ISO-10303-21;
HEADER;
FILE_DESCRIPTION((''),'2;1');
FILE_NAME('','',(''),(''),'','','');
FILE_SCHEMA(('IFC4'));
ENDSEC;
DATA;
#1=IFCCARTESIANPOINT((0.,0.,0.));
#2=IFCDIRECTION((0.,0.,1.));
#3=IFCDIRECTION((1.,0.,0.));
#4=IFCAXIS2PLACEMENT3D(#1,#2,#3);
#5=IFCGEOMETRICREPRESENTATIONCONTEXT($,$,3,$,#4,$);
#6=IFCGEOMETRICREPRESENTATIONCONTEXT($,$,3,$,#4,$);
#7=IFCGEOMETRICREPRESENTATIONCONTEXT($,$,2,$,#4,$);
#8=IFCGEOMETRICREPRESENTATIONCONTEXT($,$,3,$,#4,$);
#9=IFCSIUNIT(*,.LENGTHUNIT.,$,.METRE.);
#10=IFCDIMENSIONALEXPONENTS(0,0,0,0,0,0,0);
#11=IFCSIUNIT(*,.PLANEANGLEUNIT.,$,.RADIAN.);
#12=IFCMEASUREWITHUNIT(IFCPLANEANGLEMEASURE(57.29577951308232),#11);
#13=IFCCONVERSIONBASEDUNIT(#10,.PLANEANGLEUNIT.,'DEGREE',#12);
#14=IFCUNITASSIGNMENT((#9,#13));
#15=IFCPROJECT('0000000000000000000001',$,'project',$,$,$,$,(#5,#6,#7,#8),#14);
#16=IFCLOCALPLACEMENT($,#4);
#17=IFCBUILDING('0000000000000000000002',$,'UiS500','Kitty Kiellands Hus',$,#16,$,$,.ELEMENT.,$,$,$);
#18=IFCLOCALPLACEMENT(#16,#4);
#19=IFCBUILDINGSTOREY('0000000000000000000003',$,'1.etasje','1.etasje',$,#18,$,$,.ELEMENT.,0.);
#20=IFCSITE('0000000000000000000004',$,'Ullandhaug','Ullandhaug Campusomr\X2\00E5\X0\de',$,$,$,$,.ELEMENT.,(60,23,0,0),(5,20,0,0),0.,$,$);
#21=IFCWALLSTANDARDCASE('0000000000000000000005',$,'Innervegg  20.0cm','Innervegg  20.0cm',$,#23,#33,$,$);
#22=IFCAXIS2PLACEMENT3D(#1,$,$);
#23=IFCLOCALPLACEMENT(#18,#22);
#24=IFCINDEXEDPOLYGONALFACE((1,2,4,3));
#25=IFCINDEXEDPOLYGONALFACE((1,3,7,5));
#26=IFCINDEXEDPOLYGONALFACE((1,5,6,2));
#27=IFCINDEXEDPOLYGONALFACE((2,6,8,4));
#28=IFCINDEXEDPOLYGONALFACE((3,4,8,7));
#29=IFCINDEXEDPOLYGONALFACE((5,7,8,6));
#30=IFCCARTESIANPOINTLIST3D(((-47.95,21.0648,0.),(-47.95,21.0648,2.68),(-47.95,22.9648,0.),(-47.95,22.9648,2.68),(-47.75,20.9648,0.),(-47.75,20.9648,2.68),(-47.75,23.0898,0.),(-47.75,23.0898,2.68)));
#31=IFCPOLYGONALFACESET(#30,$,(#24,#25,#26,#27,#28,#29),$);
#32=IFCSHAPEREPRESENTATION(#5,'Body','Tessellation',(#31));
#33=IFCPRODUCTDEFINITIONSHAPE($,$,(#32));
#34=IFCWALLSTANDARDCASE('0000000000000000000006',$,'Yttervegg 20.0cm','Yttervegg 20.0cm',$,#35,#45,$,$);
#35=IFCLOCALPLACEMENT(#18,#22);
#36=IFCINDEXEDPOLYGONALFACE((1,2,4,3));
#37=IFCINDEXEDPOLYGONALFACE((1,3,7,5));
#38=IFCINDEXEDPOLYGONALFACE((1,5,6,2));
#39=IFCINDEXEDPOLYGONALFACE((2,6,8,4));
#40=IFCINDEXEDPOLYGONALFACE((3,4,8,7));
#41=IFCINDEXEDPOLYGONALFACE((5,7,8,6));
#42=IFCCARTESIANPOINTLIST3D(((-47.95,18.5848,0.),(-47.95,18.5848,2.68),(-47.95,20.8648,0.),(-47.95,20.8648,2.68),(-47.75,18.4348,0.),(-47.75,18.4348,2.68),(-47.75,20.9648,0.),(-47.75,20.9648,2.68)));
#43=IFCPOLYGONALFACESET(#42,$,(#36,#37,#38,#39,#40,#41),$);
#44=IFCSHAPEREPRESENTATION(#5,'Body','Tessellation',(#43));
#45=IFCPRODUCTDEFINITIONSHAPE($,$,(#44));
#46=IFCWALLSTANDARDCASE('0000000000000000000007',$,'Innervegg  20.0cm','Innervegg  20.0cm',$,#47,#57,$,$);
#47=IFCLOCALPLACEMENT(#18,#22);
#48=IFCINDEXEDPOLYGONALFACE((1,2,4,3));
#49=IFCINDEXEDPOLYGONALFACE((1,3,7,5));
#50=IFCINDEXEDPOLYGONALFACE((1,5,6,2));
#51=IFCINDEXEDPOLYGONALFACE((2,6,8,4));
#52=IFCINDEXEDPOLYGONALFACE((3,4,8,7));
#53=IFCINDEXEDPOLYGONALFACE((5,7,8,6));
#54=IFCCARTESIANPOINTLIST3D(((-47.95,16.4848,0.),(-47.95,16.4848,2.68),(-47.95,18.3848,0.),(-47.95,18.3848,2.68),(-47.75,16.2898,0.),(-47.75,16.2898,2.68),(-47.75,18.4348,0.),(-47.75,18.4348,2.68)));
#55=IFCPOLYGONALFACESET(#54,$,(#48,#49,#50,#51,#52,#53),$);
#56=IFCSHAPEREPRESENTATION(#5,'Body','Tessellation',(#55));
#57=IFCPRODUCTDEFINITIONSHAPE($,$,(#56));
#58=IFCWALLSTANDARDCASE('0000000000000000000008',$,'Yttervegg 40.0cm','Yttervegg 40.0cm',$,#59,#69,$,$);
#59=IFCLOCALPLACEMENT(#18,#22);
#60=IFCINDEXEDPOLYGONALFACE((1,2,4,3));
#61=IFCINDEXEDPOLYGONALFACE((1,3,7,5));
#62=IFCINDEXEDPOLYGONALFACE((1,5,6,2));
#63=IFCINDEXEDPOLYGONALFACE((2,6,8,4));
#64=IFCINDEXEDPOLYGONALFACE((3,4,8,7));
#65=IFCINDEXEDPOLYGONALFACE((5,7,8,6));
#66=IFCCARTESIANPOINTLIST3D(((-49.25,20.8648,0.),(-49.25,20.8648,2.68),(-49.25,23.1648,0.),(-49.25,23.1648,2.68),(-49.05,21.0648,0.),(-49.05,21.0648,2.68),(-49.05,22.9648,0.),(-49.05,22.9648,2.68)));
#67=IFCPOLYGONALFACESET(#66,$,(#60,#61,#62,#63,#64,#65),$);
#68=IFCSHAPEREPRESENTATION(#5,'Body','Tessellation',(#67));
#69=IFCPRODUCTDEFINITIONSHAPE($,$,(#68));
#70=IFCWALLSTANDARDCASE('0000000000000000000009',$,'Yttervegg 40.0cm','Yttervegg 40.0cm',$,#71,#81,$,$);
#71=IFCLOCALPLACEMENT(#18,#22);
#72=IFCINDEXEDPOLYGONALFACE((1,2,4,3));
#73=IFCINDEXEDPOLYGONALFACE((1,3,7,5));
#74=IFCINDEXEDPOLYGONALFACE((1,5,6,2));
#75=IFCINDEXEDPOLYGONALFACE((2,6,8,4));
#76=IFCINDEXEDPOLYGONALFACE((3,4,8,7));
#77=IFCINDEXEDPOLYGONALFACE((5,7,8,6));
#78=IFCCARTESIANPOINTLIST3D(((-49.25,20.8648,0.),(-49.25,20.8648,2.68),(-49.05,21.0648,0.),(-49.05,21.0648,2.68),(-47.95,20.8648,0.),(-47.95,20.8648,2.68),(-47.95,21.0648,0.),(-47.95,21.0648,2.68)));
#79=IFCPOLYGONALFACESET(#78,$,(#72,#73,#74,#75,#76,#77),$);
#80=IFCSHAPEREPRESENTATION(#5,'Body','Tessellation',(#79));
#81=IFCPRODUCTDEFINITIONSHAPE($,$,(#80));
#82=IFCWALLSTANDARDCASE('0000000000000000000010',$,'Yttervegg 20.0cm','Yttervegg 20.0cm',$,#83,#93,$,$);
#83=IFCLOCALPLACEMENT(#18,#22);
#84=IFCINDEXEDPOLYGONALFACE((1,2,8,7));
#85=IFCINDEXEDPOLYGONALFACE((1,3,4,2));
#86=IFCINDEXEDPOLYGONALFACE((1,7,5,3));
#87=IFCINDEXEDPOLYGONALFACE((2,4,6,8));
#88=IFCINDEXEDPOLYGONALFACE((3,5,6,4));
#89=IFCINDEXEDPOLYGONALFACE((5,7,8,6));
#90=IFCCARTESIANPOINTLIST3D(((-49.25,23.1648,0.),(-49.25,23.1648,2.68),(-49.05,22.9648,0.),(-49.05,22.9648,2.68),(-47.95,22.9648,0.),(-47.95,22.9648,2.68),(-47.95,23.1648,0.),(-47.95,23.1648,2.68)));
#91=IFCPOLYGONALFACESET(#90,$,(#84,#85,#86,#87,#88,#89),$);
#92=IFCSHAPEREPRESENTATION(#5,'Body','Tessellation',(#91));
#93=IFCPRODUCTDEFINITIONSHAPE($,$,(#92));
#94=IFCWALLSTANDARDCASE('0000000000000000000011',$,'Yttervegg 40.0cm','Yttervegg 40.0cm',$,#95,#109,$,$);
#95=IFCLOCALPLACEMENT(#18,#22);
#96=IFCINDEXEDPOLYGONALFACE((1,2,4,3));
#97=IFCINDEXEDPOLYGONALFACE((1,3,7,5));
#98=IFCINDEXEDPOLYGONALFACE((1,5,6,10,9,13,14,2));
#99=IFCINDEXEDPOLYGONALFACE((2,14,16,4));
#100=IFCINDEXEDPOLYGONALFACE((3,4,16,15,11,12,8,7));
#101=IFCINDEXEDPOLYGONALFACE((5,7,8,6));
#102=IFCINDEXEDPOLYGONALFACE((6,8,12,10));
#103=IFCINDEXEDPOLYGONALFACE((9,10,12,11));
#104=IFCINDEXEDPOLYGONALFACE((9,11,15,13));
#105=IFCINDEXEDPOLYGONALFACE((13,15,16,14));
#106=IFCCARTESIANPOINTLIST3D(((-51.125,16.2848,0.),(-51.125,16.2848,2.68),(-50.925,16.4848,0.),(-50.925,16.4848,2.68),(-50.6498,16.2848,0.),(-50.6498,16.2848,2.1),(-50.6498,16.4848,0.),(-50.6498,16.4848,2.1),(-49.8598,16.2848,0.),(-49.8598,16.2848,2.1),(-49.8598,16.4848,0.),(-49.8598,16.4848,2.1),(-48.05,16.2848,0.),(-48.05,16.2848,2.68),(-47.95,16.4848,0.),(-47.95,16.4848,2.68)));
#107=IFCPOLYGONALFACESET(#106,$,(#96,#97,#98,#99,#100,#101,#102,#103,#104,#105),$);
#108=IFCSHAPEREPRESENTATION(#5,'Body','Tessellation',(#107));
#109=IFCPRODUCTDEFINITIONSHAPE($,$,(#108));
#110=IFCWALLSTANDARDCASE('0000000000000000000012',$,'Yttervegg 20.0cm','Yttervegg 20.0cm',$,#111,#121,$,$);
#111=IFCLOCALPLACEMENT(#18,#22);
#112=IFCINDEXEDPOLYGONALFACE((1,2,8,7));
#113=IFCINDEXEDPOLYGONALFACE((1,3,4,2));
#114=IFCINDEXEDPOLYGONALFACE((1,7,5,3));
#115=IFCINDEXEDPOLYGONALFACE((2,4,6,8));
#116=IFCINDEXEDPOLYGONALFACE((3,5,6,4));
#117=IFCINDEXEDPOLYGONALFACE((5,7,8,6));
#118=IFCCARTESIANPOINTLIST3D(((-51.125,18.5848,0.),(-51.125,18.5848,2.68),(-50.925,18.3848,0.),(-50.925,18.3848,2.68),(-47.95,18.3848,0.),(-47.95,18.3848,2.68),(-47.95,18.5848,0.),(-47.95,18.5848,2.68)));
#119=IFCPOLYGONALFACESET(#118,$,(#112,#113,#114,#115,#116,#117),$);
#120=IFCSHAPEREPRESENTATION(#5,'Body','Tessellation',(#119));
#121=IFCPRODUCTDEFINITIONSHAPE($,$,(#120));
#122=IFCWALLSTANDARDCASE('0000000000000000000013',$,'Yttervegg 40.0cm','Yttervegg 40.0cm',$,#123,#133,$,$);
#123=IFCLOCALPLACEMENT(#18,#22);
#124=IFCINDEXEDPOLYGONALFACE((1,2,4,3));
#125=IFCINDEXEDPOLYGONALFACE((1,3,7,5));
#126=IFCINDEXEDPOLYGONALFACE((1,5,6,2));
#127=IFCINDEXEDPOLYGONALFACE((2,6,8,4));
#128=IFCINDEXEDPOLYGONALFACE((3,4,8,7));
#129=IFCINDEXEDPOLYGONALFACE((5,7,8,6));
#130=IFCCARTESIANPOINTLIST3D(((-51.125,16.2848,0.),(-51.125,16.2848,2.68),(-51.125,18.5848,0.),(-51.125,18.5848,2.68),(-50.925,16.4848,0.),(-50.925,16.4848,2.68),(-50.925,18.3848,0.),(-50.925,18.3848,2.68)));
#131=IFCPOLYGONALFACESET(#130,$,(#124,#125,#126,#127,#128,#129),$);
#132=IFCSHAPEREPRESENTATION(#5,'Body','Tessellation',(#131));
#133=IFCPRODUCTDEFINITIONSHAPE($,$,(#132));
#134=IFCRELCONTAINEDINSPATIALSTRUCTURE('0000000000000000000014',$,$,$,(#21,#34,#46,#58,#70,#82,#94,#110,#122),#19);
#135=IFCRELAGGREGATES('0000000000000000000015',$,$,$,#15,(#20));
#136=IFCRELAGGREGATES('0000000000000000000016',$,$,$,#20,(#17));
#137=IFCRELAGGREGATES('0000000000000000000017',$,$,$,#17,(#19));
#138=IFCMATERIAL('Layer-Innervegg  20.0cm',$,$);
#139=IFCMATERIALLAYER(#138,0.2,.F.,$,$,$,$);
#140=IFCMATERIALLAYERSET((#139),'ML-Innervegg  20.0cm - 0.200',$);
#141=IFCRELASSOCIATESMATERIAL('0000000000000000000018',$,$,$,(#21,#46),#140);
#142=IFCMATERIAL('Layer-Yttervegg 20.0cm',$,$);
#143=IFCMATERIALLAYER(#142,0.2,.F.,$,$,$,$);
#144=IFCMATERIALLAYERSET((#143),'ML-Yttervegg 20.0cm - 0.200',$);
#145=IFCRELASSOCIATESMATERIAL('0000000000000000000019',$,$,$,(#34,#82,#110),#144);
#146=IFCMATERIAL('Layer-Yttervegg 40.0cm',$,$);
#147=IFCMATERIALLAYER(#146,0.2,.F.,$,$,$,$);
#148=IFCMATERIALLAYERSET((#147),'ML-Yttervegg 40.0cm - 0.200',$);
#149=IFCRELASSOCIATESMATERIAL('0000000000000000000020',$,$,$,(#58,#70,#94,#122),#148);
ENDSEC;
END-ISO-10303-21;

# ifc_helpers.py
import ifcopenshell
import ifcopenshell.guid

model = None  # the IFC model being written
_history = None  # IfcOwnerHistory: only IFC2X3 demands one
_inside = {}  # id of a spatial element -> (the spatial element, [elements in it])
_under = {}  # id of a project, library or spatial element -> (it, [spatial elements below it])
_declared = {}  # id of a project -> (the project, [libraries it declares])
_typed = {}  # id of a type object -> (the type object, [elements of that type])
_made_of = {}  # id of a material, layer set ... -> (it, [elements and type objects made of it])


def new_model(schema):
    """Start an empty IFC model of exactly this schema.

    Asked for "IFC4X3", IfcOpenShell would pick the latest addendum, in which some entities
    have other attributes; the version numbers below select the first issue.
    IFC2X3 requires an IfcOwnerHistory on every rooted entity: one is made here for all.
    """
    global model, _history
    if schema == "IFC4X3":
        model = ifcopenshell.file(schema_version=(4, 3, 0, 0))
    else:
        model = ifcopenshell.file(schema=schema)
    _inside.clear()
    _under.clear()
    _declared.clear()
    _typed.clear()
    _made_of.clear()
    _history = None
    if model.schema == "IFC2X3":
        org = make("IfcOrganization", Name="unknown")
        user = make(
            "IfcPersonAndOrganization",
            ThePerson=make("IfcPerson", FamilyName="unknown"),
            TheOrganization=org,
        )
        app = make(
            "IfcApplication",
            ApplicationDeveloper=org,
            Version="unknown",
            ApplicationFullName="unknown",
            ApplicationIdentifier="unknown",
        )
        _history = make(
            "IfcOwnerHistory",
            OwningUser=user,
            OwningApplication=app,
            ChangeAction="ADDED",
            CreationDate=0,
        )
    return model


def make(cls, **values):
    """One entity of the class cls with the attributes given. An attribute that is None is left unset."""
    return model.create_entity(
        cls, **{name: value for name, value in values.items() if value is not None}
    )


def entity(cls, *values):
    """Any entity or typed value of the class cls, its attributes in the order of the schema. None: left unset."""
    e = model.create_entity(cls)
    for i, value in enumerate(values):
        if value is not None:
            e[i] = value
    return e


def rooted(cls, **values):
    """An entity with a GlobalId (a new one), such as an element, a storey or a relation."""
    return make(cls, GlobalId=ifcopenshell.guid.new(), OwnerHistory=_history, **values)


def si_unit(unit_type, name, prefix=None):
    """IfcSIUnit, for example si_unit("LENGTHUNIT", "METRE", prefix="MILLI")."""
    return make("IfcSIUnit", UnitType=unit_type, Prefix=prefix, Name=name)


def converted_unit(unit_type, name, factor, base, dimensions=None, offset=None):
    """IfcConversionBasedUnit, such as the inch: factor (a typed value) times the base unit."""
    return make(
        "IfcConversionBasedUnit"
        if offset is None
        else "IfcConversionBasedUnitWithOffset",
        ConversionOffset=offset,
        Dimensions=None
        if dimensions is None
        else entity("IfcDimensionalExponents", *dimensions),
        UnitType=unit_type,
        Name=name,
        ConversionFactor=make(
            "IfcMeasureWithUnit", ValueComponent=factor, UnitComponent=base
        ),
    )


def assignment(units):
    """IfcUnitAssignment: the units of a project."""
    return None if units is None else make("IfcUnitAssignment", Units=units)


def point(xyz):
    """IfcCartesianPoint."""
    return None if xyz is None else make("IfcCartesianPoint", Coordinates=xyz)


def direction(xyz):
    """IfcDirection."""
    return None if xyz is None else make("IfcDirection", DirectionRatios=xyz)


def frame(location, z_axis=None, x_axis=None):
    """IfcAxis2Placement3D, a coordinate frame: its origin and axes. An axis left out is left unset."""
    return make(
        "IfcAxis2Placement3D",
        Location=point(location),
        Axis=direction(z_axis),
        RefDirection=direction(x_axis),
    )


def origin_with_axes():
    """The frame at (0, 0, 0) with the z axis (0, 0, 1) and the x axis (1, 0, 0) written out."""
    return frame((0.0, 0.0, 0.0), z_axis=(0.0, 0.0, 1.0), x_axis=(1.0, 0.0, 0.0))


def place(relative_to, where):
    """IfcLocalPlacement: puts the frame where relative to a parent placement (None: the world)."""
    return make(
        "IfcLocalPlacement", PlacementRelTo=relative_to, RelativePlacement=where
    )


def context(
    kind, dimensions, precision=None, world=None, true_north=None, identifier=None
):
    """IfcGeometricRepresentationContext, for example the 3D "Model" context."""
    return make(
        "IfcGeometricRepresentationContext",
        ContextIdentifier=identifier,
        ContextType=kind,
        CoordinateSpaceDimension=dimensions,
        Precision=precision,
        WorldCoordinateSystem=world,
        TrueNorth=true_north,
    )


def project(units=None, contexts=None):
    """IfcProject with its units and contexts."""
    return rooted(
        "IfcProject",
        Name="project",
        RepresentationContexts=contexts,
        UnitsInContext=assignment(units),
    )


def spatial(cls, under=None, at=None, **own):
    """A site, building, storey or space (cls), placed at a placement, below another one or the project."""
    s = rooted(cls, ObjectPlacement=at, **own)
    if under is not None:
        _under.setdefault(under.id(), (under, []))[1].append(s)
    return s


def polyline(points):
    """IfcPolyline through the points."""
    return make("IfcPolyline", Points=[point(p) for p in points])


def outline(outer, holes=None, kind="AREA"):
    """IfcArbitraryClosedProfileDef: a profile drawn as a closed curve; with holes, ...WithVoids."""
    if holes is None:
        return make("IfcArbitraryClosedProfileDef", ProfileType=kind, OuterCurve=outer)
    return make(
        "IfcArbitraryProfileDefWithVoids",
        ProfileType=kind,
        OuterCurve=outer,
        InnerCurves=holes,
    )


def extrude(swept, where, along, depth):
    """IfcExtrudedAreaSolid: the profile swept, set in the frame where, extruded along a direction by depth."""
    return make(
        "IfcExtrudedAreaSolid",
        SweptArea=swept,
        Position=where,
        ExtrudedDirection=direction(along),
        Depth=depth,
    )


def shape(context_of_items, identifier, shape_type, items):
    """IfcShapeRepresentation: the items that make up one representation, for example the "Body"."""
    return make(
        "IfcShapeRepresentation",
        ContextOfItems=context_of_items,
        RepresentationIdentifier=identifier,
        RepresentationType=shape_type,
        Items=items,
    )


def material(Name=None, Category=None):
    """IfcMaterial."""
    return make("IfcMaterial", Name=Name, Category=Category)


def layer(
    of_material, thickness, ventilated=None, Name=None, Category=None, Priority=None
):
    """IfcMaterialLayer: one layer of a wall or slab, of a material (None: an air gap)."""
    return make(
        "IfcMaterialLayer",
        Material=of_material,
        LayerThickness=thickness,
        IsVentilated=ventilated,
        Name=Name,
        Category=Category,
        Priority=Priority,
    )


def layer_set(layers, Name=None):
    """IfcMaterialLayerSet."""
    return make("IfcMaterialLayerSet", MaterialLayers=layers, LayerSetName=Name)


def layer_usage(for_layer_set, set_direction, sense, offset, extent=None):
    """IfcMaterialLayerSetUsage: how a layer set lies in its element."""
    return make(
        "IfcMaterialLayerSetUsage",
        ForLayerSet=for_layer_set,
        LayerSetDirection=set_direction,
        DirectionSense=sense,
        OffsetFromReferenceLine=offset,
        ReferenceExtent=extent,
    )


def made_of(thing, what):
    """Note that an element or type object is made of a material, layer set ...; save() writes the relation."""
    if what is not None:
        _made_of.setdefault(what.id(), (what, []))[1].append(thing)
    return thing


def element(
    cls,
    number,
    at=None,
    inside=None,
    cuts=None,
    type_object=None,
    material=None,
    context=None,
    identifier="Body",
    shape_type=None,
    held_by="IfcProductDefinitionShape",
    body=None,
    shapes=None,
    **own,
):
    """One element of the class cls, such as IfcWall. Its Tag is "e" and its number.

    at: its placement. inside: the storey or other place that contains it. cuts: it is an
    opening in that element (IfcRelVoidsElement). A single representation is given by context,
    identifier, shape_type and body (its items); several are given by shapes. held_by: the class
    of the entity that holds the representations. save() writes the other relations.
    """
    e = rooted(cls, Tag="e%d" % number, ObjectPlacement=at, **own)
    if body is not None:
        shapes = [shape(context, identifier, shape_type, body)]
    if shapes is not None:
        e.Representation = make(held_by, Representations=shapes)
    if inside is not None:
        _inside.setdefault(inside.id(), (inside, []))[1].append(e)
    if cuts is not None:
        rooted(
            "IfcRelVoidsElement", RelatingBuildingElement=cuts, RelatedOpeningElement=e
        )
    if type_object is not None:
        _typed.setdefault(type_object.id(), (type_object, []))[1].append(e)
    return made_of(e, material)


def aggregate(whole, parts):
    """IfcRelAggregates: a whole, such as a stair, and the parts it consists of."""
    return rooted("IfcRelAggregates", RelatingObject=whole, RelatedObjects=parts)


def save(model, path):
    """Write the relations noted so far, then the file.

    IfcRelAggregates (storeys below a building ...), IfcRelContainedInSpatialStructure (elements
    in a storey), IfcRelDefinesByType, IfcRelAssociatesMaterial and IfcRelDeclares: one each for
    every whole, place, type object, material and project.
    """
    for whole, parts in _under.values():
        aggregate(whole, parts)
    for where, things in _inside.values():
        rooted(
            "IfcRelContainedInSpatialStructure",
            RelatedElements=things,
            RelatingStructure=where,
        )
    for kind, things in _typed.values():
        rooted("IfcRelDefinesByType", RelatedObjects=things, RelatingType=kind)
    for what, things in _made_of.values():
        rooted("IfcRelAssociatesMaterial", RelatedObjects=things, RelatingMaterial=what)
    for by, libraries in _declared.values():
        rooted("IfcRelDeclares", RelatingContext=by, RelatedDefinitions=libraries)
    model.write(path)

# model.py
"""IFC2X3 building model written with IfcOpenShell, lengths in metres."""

from ifc_helpers import new_model, entity, si_unit, converted_unit, frame, origin_with_axes, place, context, project, spatial, polyline, outline, extrude, material, layer, layer_set, layer_usage, element, save


model = new_model("IFC2X3")

# Units and contexts
context_of_model_1 = context(None, 3, world=origin_with_axes())
context_of_model_2 = context(None, 3, world=origin_with_axes())
context_of_model_3 = context(None, 2, world=origin_with_axes())
context_of_model_4 = context(None, 3, world=origin_with_axes())
ifc_project = project(units=[si_unit("LENGTHUNIT", "METRE"), converted_unit("PLANEANGLEUNIT", "DEGREE", entity("IfcPlaneAngleMeasure", 57.29577951308232), si_unit("PLANEANGLEUNIT", "RADIAN"), dimensions=[0, 0, 0, 0, 0, 0, 0])], contexts=[context_of_model_1, context_of_model_2, context_of_model_3, context_of_model_4])

# Site, building, storey
site = spatial("IfcSite", under=ifc_project, Name="Ullandhaug", Description="Ullandhaug Campusområde", CompositionType="ELEMENT", RefLatitude=(60, 23, 0, 0), RefLongitude=(5, 20, 0, 0), RefElevation=0.0)
building_placement = place(None, origin_with_axes())
building = spatial("IfcBuilding", under=site, at=building_placement, Name="UiS500", Description="Kitty Kiellands Hus", CompositionType="ELEMENT")
storey_placement = place(building_placement, origin_with_axes())
storey = spatial("IfcBuildingStorey", under=building, at=storey_placement, Name="1.etasje", Description="1.etasje", CompositionType="ELEMENT", Elevation=0.0)

# Shared definitions
ifc_material_1 = material(Name="Layer-Yttervegg 20.0cm")
ifc_layer_1 = layer(ifc_material_1, 0.2, ventilated=False)
ifc_layer_set_1 = layer_set([ifc_layer_1], Name="ML-Yttervegg 20.0cm - 0.200")
ifc_layer_usage_1 = layer_usage(ifc_layer_set_1, "AXIS2", "POSITIVE", 0.0)

# Walls
ifc_material_2 = material(Name="Layer-Innervegg  20.0cm")
ifc_layer_2 = layer(ifc_material_2, 0.2, ventilated=False)
ifc_layer_set_2 = layer_set([ifc_layer_2], Name="ML-Innervegg  20.0cm - 0.200")
ifc_layer_usage_2 = layer_usage(ifc_layer_set_2, "AXIS2", "POSITIVE", 0.0)
wall_1_placement = place(storey_placement, frame((-47.95, 22.9648, 0.0), z_axis=(0.0, 0.0, 1.0), x_axis=(0.0, -1.0, 0.0)))
element("IfcWallStandardCase", 1, at=wall_1_placement, inside=storey, material=ifc_layer_usage_2, Name="Innervegg  20.0cm", Description="Innervegg  20.0cm", context=context_of_model_1, shape_type="SweptSolid", body=[
    extrude(outline(polyline([(0.0, 0.0), (1.9, 0.0), (2.0, 0.2), (-0.125, 0.2), (0.0, 0.0)])), frame((0.0, 0.0, 0.0), z_axis=(0.0, 0.0, 1.0), x_axis=(1.0, 0.0, 0.0)), (0.0, 0.0, 1.0), 2.68),
])
wall_2_placement = place(storey_placement, frame((-47.95, 20.8648, 0.0), z_axis=(0.0, 0.0, 1.0), x_axis=(0.0, -1.0, 0.0)))
element("IfcWallStandardCase", 2, at=wall_2_placement, inside=storey, material=ifc_layer_usage_1, Name="Yttervegg 20.0cm", Description="Yttervegg 20.0cm", context=context_of_model_1, shape_type="SweptSolid", body=[
    extrude(outline(polyline([(0.0, 0.0), (2.28, 0.0), (2.43, 0.2), (-0.1, 0.2), (0.0, 0.0)])), frame((0.0, 0.0, 0.0), z_axis=(0.0, 0.0, 1.0), x_axis=(1.0, 0.0, 0.0)), (0.0, 0.0, 1.0), 2.68),
])
wall_3_placement = place(storey_placement, frame((-47.95, 18.3848, 0.0), z_axis=(0.0, 0.0, 1.0), x_axis=(0.0, -1.0, 0.0)))
element("IfcWallStandardCase", 3, at=wall_3_placement, inside=storey, material=ifc_layer_usage_2, Name="Innervegg  20.0cm", Description="Innervegg  20.0cm", context=context_of_model_1, shape_type="SweptSolid", body=[
    extrude(outline(polyline([(0.0, 0.0), (1.9, 0.0), (2.095, 0.2), (-0.05, 0.2), (0.0, 0.0)])), frame((0.0, 0.0, 0.0), z_axis=(0.0, 0.0, 1.0), x_axis=(1.0, 0.0, 0.0)), (0.0, 0.0, 1.0), 2.68),
])
ifc_material_3 = material(Name="Layer-Yttervegg 40.0cm")
ifc_layer_3 = layer(ifc_material_3, 0.2, ventilated=False)
ifc_layer_set_3 = layer_set([ifc_layer_3], Name="ML-Yttervegg 40.0cm - 0.200")
ifc_layer_usage_3 = layer_usage(ifc_layer_set_3, "AXIS2", "POSITIVE", 0.0)
wall_4_placement = place(storey_placement, frame((-49.25, 23.1648, 0.0), z_axis=(0.0, 0.0, 1.0), x_axis=(0.0, -1.0, 0.0)))
element("IfcWallStandardCase", 4, at=wall_4_placement, inside=storey, material=ifc_layer_usage_3, Name="Yttervegg 40.0cm", Description="Yttervegg 40.0cm", context=context_of_model_1, shape_type="SweptSolid", body=[
    extrude(outline(polyline([(0.0, 0.0), (2.3, 0.0), (2.1, 0.2), (0.2, 0.2), (0.0, 0.0)])), frame((0.0, 0.0, 0.0), z_axis=(0.0, 0.0, 1.0), x_axis=(1.0, 0.0, 0.0)), (0.0, 0.0, 1.0), 2.68),
])
wall_5_placement = place(storey_placement, frame((-49.25, 20.8648, 0.0), z_axis=(0.0, 0.0, 1.0), x_axis=(1.0, 0.0, 0.0)))
element("IfcWallStandardCase", 5, at=wall_5_placement, inside=storey, material=ifc_layer_usage_3, Name="Yttervegg 40.0cm", Description="Yttervegg 40.0cm", context=context_of_model_1, shape_type="SweptSolid", body=[
    extrude(outline(polyline([(0.0, 0.0), (1.3, 0.0), (1.3, 0.2), (0.2, 0.2), (0.0, 0.0)])), origin_with_axes(), (0.0, 0.0, 1.0), 2.68),
])
wall_6_placement = place(storey_placement, frame((-47.95, 23.1648, 0.0), z_axis=(0.0, 0.0, 1.0), x_axis=(-1.0, 0.0, 0.0)))
element("IfcWallStandardCase", 6, at=wall_6_placement, inside=storey, material=ifc_layer_usage_1, Name="Yttervegg 20.0cm", Description="Yttervegg 20.0cm", context=context_of_model_1, shape_type="SweptSolid", body=[
    extrude(outline(polyline([(0.0, 0.0), (1.3, 0.0), (1.1, 0.2), (0.0, 0.2), (0.0, 0.0)])), frame((0.0, 0.0, 0.0), z_axis=(0.0, 0.0, 1.0), x_axis=(1.0, 0.0, 0.0)), (0.0, 0.0, 1.0), 2.68),
])

# Wall, opening
wall_7_placement = place(storey_placement, frame((-51.125, 16.2848, 0.0), z_axis=(0.0, 0.0, 1.0), x_axis=(1.0, 0.0, 0.0)))
wall_7 = element("IfcWallStandardCase", 7, at=wall_7_placement, inside=storey, material=ifc_layer_usage_3, Name="Yttervegg 40.0cm", Description="Yttervegg 40.0cm", context=context_of_model_1, shape_type="SweptSolid", body=[
    extrude(outline(polyline([(0.0, 0.0), (3.075, 0.0), (3.175, 0.2), (0.2, 0.2), (0.0, 0.0)])), origin_with_axes(), (0.0, 0.0, 1.0), 2.68),
])
opening_1_placement = place(wall_7_placement, frame((0.4752, 0.2, 0.0), z_axis=(0.0, 0.0, 1.0), x_axis=(1.0, 0.0, 0.0)))
element("IfcOpeningElement", 8, at=opening_1_placement, cuts=wall_7, context=context_of_model_1, shape_type="SweptSolid", body=[
    extrude(outline(polyline([(0.0, 0.0), (2.1, 0.0), (2.1, 0.79), (0.0, 0.79), (0.0, 0.0)])), frame((0.0, 0.0, 0.0), z_axis=(0.0, 1.0, 0.0), x_axis=(0.0, 0.0, 1.0)), (0.0, 0.0, -1.0), 0.2),
])

# Walls
wall_8_placement = place(storey_placement, frame((-47.95, 18.5848, 0.0), z_axis=(0.0, 0.0, 1.0), x_axis=(-1.0, 0.0, 0.0)))
element("IfcWallStandardCase", 9, at=wall_8_placement, inside=storey, material=ifc_layer_usage_1, Name="Yttervegg 20.0cm", Description="Yttervegg 20.0cm", context=context_of_model_1, shape_type="SweptSolid", body=[
    extrude(outline(polyline([(0.0, 0.0), (3.175, 0.0), (2.975, 0.2), (0.0, 0.2), (0.0, 0.0)])), frame((0.0, 0.0, 0.0), z_axis=(0.0, 0.0, 1.0), x_axis=(1.0, 0.0, 0.0)), (0.0, 0.0, 1.0), 2.68),
])
wall_9_placement = place(storey_placement, frame((-51.125, 18.5848, 0.0), z_axis=(0.0, 0.0, 1.0), x_axis=(0.0, -1.0, 0.0)))
element("IfcWallStandardCase", 10, at=wall_9_placement, inside=storey, material=ifc_layer_usage_3, Name="Yttervegg 40.0cm", Description="Yttervegg 40.0cm", context=context_of_model_1, shape_type="SweptSolid", body=[
    extrude(outline(polyline([(0.0, 0.0), (2.3, 0.0), (2.1, 0.2), (0.2, 0.2), (0.0, 0.0)])), frame((0.0, 0.0, 0.0), z_axis=(0.0, 0.0, 1.0), x_axis=(1.0, 0.0, 0.0)), (0.0, 0.0, 1.0), 2.68),
])

save(model, "model.ifc")
